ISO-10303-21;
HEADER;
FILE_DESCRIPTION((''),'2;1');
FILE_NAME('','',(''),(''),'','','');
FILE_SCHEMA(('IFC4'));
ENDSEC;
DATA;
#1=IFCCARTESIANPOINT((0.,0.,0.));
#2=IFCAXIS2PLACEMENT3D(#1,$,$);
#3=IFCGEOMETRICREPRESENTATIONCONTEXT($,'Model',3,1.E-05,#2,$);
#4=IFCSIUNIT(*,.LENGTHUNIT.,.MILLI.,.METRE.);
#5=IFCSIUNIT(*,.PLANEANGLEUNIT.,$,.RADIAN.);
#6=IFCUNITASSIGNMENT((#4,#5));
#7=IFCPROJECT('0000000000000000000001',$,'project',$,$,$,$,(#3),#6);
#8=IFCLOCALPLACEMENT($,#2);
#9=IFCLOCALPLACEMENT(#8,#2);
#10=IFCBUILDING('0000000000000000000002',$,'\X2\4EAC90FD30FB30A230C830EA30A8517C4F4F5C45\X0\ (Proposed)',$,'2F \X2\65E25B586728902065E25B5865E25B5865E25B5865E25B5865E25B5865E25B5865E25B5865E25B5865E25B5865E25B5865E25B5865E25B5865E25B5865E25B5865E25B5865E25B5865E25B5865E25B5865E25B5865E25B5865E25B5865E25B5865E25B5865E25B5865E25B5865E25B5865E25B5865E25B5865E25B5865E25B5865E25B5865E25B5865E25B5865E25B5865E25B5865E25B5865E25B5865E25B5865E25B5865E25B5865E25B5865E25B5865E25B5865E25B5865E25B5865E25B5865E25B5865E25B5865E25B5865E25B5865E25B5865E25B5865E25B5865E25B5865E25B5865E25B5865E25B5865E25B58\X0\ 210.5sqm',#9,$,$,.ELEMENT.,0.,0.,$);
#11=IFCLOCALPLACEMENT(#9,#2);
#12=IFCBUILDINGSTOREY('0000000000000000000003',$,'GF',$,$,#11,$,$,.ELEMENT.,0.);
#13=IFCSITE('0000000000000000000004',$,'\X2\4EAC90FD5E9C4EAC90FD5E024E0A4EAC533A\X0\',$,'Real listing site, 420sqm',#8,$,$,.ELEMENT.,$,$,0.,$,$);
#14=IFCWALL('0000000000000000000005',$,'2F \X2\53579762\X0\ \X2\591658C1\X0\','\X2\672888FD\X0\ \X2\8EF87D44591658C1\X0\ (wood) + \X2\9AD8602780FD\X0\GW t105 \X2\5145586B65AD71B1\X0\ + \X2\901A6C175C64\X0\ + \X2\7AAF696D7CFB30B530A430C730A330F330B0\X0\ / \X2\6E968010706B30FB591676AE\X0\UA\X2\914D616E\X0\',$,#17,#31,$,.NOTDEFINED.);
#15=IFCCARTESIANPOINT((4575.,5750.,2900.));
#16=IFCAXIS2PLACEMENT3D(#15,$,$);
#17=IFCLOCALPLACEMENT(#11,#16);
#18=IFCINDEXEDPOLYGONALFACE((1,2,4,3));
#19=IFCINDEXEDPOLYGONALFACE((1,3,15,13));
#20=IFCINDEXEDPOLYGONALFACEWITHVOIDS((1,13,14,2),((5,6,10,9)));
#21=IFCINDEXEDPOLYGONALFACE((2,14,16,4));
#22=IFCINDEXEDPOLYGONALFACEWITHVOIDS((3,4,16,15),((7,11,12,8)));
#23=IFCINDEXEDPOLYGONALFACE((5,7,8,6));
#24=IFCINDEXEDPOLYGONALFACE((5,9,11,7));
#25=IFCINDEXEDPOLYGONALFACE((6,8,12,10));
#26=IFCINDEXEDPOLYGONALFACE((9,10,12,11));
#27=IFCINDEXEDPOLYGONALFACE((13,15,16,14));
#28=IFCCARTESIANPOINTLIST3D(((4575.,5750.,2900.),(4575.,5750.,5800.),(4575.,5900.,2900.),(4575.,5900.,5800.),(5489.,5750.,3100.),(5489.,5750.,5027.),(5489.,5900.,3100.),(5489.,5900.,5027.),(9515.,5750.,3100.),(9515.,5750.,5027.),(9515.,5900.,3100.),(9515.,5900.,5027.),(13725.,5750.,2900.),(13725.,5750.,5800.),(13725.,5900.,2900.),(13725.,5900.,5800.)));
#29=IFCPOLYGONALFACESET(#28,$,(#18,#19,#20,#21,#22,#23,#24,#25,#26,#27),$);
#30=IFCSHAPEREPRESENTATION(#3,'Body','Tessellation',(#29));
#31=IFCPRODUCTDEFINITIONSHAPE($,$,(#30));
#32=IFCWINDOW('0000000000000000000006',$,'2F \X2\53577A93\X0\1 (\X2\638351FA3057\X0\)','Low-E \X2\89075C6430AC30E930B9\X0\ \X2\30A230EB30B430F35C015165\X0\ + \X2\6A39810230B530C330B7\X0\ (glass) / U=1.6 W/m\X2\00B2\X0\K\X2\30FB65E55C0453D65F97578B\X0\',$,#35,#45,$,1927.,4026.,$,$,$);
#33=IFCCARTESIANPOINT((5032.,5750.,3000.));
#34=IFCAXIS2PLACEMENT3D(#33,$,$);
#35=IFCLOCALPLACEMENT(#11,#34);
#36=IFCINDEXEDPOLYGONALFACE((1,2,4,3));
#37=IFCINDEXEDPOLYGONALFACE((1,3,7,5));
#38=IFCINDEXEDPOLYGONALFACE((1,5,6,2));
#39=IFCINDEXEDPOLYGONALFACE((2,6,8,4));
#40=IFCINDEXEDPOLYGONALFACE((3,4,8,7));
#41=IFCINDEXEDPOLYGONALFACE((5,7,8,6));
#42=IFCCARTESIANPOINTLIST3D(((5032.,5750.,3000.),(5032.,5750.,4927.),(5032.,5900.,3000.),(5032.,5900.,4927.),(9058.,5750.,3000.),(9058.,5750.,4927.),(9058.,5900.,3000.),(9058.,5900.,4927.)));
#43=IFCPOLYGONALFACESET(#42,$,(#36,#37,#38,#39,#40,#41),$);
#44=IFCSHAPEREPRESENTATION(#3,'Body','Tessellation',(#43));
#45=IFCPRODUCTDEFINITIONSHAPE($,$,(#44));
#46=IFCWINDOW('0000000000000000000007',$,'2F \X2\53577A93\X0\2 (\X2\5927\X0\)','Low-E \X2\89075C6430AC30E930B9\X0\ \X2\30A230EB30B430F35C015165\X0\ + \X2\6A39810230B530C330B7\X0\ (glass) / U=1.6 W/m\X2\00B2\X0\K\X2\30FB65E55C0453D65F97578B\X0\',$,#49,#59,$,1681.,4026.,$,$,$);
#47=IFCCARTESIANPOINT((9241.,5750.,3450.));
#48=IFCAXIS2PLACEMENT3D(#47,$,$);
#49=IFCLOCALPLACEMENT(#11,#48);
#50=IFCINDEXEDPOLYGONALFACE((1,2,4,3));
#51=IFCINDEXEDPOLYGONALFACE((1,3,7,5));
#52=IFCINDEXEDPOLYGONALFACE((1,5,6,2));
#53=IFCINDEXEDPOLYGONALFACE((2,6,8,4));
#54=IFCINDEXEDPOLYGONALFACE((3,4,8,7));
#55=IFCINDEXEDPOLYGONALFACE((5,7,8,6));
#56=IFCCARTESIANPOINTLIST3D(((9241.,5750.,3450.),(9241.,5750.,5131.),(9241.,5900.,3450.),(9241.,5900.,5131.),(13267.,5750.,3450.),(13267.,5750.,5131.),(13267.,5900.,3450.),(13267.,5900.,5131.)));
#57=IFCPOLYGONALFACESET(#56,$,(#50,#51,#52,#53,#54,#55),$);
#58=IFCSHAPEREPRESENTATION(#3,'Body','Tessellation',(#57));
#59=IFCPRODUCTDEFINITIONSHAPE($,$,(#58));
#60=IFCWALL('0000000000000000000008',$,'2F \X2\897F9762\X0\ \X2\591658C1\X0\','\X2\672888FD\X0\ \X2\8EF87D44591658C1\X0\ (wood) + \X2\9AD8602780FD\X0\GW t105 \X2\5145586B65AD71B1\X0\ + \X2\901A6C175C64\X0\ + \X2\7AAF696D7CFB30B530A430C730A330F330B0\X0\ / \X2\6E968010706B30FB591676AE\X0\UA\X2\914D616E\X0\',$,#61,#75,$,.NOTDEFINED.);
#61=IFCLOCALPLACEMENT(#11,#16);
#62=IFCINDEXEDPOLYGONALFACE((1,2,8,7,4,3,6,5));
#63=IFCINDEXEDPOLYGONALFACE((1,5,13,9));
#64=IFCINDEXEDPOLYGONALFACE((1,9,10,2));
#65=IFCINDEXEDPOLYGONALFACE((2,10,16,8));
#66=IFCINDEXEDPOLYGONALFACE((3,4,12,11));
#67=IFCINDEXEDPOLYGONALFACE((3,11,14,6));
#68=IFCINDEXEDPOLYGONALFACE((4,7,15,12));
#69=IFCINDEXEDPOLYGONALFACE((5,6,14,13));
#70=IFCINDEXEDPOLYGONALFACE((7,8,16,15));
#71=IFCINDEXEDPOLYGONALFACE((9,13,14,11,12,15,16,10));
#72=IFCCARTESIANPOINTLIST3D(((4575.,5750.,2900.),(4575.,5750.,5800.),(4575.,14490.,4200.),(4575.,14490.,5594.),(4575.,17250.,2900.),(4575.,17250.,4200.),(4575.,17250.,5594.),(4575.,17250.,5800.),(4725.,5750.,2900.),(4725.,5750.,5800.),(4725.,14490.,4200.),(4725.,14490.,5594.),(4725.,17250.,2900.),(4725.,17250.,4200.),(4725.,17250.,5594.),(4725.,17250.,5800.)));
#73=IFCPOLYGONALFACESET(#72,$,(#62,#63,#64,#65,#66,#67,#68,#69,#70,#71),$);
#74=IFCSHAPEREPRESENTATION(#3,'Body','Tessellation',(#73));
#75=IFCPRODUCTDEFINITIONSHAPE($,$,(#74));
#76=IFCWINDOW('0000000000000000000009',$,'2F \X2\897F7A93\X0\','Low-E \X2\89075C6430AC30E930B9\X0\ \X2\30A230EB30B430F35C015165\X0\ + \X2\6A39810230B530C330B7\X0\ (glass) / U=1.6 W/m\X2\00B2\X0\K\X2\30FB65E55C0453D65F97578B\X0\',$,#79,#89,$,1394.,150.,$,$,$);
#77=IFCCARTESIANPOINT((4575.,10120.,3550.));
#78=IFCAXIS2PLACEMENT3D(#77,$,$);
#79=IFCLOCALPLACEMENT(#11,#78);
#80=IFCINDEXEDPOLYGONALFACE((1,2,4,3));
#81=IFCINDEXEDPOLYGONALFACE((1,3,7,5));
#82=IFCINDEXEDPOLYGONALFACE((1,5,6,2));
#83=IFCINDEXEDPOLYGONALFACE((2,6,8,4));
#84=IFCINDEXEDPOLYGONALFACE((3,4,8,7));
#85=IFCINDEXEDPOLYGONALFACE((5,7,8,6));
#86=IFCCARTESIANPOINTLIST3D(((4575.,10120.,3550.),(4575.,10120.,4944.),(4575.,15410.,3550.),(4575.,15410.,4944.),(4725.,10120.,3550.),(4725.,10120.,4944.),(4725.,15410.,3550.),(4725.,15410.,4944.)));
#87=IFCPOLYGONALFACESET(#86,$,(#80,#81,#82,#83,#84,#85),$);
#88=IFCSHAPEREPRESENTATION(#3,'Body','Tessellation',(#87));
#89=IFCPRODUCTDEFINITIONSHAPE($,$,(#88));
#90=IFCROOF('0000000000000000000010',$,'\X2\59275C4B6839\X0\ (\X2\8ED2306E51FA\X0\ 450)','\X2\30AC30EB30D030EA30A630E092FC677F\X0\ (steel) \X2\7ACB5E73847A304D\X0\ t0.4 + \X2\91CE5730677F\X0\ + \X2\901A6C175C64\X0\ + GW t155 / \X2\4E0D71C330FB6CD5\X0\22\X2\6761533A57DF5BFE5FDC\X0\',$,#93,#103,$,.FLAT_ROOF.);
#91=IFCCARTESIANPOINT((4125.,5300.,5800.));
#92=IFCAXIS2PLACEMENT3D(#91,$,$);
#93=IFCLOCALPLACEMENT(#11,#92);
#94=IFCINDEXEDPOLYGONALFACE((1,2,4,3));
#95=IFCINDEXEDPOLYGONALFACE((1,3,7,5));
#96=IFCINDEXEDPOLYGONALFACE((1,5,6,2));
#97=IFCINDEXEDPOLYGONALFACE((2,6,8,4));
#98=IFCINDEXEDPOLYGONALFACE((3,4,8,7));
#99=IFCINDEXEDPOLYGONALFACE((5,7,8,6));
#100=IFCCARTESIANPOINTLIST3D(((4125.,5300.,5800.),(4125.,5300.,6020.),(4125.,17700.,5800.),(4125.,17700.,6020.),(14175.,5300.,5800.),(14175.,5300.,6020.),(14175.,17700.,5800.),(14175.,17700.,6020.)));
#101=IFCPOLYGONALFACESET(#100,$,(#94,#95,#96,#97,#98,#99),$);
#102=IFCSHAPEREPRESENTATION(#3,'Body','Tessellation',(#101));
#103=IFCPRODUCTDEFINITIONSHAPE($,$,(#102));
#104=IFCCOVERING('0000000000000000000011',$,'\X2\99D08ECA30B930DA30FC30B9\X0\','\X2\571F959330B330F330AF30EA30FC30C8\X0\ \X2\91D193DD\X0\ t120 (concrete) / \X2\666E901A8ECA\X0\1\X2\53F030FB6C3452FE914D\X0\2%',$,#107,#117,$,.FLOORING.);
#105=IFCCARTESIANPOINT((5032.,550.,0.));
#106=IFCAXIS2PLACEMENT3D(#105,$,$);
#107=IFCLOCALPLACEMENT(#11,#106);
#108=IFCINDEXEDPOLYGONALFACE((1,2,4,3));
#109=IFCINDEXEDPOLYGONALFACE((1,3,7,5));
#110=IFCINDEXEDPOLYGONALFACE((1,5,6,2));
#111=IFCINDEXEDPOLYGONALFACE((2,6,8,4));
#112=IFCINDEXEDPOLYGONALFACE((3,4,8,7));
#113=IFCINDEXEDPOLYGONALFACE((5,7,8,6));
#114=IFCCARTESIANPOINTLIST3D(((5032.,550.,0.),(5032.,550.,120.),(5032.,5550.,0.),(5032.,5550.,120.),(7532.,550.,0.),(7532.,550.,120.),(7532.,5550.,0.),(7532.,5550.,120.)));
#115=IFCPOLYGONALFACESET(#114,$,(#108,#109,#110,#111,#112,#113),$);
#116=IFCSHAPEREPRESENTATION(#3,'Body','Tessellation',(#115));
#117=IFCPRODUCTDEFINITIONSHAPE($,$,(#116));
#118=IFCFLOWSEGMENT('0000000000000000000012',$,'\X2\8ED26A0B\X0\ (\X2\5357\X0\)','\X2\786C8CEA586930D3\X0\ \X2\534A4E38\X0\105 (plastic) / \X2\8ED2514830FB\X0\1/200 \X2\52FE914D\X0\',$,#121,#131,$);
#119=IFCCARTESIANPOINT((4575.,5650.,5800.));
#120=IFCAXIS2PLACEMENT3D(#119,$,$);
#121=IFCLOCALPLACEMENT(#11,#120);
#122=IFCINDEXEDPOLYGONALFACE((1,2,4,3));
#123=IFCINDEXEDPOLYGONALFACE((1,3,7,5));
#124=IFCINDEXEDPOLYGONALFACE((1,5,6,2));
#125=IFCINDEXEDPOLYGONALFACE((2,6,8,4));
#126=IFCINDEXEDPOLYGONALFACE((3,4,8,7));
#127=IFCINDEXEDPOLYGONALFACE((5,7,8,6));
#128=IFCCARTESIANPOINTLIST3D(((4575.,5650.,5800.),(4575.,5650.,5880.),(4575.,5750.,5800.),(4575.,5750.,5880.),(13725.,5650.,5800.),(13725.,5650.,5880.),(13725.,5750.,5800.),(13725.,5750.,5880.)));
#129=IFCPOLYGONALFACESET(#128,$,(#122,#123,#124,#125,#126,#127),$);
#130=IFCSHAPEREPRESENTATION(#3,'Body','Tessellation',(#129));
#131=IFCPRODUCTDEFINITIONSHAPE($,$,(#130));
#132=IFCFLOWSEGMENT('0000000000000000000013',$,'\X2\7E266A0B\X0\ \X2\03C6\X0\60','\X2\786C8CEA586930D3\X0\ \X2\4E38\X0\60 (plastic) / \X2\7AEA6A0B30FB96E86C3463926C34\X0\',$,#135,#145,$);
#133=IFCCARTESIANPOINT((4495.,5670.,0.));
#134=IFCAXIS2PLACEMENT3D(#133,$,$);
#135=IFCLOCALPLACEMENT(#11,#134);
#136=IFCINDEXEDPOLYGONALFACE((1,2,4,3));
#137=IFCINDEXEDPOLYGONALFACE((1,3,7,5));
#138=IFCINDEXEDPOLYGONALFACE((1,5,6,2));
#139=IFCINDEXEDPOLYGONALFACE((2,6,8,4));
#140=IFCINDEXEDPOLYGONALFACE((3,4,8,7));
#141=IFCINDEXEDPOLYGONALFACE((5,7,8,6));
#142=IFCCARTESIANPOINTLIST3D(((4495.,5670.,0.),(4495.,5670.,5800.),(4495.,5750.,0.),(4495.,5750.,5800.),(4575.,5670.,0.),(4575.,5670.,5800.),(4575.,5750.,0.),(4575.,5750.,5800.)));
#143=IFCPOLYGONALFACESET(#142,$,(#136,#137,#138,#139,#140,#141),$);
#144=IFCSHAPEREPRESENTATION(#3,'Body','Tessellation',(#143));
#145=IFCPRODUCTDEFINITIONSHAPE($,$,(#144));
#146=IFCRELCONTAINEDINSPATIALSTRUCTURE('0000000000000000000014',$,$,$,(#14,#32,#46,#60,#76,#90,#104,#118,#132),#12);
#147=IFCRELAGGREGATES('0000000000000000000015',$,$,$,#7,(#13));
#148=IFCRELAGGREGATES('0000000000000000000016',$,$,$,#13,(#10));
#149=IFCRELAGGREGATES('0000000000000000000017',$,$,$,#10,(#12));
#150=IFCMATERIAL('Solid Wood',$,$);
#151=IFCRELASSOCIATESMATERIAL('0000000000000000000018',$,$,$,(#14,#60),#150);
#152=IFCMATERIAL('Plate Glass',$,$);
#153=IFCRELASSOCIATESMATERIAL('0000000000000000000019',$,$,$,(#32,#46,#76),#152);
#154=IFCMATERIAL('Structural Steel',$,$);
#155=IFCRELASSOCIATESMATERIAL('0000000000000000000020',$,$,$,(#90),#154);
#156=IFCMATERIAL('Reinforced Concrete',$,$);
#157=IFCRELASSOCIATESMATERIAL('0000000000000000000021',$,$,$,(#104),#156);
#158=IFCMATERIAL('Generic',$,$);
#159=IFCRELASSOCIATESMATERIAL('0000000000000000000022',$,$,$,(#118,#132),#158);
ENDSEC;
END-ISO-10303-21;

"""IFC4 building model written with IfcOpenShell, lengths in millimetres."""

from ifc_helpers import new_model, si_unit, frame, frame_2d, origin, place, context, project, spatial, rectangle, extrude, material, element, fill, save


model = new_model("IFC4")

# Units and contexts
model_context = context("Model", 3, precision=1e-05, world=origin())
ifc_project = project(units=[si_unit("LENGTHUNIT", "METRE", prefix="MILLI"), si_unit("PLANEANGLEUNIT", "RADIAN")], contexts=[model_context])

# Site, building, storey
site_placement = place(None, origin())
site = spatial("IfcSite", under=ifc_project, at=site_placement, Name="京都府京都市上京区", ObjectType="Real listing site, 420sqm", CompositionType="ELEMENT", RefElevation=0.0)
building_placement = place(site_placement, origin())
building = spatial("IfcBuilding", under=site, at=building_placement, Name="京都・アトリエ兼住居 (Proposed)", ObjectType="2F 既存木造既存既存既存既存既存既存既存既存既存既存既存既存既存既存既存既存既存既存既存既存既存既存既存既存既存既存既存既存既存既存既存既存既存既存既存既存既存既存既存既存既存既存既存既存既存既存既存既存既存既存既存既存既存既存既存既存既存既存 210.5sqm", CompositionType="ELEMENT", ElevationOfRefHeight=0.0, ElevationOfTerrain=0.0)
storey_placement = place(building_placement, origin())
storey = spatial("IfcBuildingStorey", under=building, at=storey_placement, Name="GF", CompositionType="ELEMENT", Elevation=0.0)

# Shared definitions
ifc_material_1 = material(Name="Solid Wood")

# Shared definitions
ifc_material_2 = material(Name="Reinforced Concrete")

# Shared definitions
ifc_material_3 = material(Name="Plate Glass")

# Wall, openings, windows
wall_1_placement = place(storey_placement, frame((4575.0, 5750.0, 2900.0)))
wall_1 = element("IfcWall", 1, at=wall_1_placement, inside=storey, material=ifc_material_1, Name="2F 南面 外壁", Description="木製 軸組外壁 (wood) + 高性能GW t105 充填断熱 + 通気層 + 窯業系サイディング / 準耐火・外皮UA配慮", PredefinedType="NOTDEFINED", context=model_context, shape_type="SweptSolid", body=[
    extrude(rectangle(XDim=9150.0, YDim=150.0, at=frame_2d((4575.0, 75.0))), frame((4575.0, 5750.0, 2900.0)), (0.0, 0.0, 1.0), 2900.0),
])
opening_1_placement = place(storey_placement, frame((5032.0, 5750.0, 3000.0)))
opening_1 = element("IfcOpeningElement", 2, at=opening_1_placement, cuts=wall_1, PredefinedType="NOTDEFINED", context=model_context, shape_type="SweptSolid", body=[
    extrude(rectangle(XDim=4026.0, YDim=150.0, at=frame_2d((2013.0, 75.0))), frame((5032.0, 5750.0, 3000.0)), (0.0, 0.0, 1.0), 1927.0),
])
opening_2_placement = place(storey_placement, frame((9241.0, 5750.0, 3450.0)))
opening_2 = element("IfcOpeningElement", 3, at=opening_2_placement, cuts=wall_1, PredefinedType="NOTDEFINED", context=model_context, shape_type="SweptSolid", body=[
    extrude(rectangle(XDim=4026.0, YDim=150.0, at=frame_2d((2013.0, 75.0))), frame((9241.0, 5750.0, 3450.0)), (0.0, 0.0, 1.0), 1681.0),
])
window_1_placement = place(storey_placement, frame((5032.0, 5750.0, 3000.0)))
window_1 = element("IfcWindow", 4, at=window_1_placement, inside=storey, material=ifc_material_3, Name="2F 南窓1 (掃出し)", Description="Low-E 複層ガラス アルゴン封入 + 樹脂サッシ (glass) / U=1.6 W/m²K・日射取得型", OverallHeight=1927.0, OverallWidth=4026.0, context=model_context, shape_type="SweptSolid", body=[
    extrude(rectangle(XDim=4026.0, YDim=150.0, at=frame_2d((2013.0, 75.0))), frame((5032.0, 5750.0, 3000.0)), (0.0, 0.0, 1.0), 1927.0),
])
fill(opening_1, window_1)
window_2_placement = place(storey_placement, frame((9241.0, 5750.0, 3450.0)))
window_2 = element("IfcWindow", 5, at=window_2_placement, inside=storey, material=ifc_material_3, Name="2F 南窓2 (大)", Description="Low-E 複層ガラス アルゴン封入 + 樹脂サッシ (glass) / U=1.6 W/m²K・日射取得型", OverallHeight=1681.0, OverallWidth=4026.0, context=model_context, shape_type="SweptSolid", body=[
    extrude(rectangle(XDim=4026.0, YDim=150.0, at=frame_2d((2013.0, 75.0))), frame((9241.0, 5750.0, 3450.0)), (0.0, 0.0, 1.0), 1681.0),
])
fill(opening_2, window_2)

# Wall, opening, window
wall_2_placement = place(storey_placement, frame((4575.0, 5750.0, 2900.0)))
wall_2 = element("IfcWall", 6, at=wall_2_placement, inside=storey, material=ifc_material_1, Name="2F 西面 外壁", Description="木製 軸組外壁 (wood) + 高性能GW t105 充填断熱 + 通気層 + 窯業系サイディング / 準耐火・外皮UA配慮", PredefinedType="NOTDEFINED", context=model_context, shape_type="SweptSolid", body=[
    extrude(rectangle(XDim=150.0, YDim=11500.0, at=frame_2d((75.0, 5750.0))), frame((4575.0, 5750.0, 2900.0)), (0.0, 0.0, 1.0), 2900.0),
])
opening_3_placement = place(storey_placement, frame((4575.0, 10120.0, 3550.0)))
opening_3 = element("IfcOpeningElement", 7, at=opening_3_placement, cuts=wall_2, PredefinedType="NOTDEFINED", context=model_context, shape_type="SweptSolid", body=[
    extrude(rectangle(XDim=150.0, YDim=5290.0, at=frame_2d((75.0, 2645.0))), frame((4575.0, 10120.0, 3550.0)), (0.0, 0.0, 1.0), 1394.0),
])
window_3_placement = place(storey_placement, frame((4575.0, 10120.0, 3550.0)))
window_3 = element("IfcWindow", 8, at=window_3_placement, inside=storey, material=ifc_material_3, Name="2F 西窓", Description="Low-E 複層ガラス アルゴン封入 + 樹脂サッシ (glass) / U=1.6 W/m²K・日射取得型", OverallHeight=1394.0, OverallWidth=150.0, context=model_context, shape_type="SweptSolid", body=[
    extrude(rectangle(XDim=150.0, YDim=5290.0, at=frame_2d((75.0, 2645.0))), frame((4575.0, 10120.0, 3550.0)), (0.0, 0.0, 1.0), 1394.0),
])
fill(opening_3, window_3)

# Roof
ifc_material_4 = material(Name="Structural Steel")
roof_placement = place(storey_placement, frame((4125.0, 5300.0, 5800.0)))
element("IfcRoof", 9, at=roof_placement, inside=storey, material=ifc_material_4, Name="大屋根 (軒の出 450)", Description="ガルバリウム鋼板 (steel) 立平葺き t0.4 + 野地板 + 通気層 + GW t155 / 不燃・法22条区域対応", PredefinedType="FLAT_ROOF", context=model_context, shape_type="SweptSolid", body=[
    extrude(rectangle(XDim=10050.0, YDim=12400.0, at=frame_2d((5025.0, 6200.0))), frame((4125.0, 5300.0, 5800.0)), (0.0, 0.0, 1.0), 220.0),
])

# Covering
covering_placement = place(storey_placement, frame((5032.0, 550.0, 0.0)))
element("IfcCovering", 10, at=covering_placement, inside=storey, material=ifc_material_2, Name="駐車スペース", Description="土間コンクリート 金鏝 t120 (concrete) / 普通車1台・水勾配2%", PredefinedType="FLOORING", context=model_context, shape_type="SweptSolid", body=[
    extrude(rectangle(XDim=2500.0, YDim=5000.0, at=frame_2d((1250.0, 2500.0))), frame((5032.0, 550.0, 0.0)), (0.0, 0.0, 1.0), 120.0),
])

# Flow segments
ifc_material_5 = material(Name="Generic")
flow_segment_1_placement = place(storey_placement, frame((4575.0, 5650.0, 5800.0)))
element("IfcFlowSegment", 11, at=flow_segment_1_placement, inside=storey, material=ifc_material_5, Name="軒樋 (南)", Description="硬質塩ビ 半丸105 (plastic) / 軒先・1/200 勾配", context=model_context, shape_type="SweptSolid", body=[
    extrude(rectangle(XDim=9150.0, YDim=100.0, at=frame_2d((4575.0, 50.0))), frame((4575.0, 5650.0, 5800.0)), (0.0, 0.0, 1.0), 80.0),
])
flow_segment_2_placement = place(storey_placement, frame((4495.0, 5670.0, 0.0)))
element("IfcFlowSegment", 12, at=flow_segment_2_placement, inside=storey, material=ifc_material_5, Name="縦樋 φ60", Description="硬質塩ビ 丸60 (plastic) / 竪樋・雨水排水", context=model_context, shape_type="SweptSolid", body=[
    extrude(rectangle(XDim=80.0, YDim=80.0, at=frame_2d((40.0, 40.0))), frame((4495.0, 5670.0, 0.0)), (0.0, 0.0, 1.0), 5800.0),
])

save(model, "model.ifc")
